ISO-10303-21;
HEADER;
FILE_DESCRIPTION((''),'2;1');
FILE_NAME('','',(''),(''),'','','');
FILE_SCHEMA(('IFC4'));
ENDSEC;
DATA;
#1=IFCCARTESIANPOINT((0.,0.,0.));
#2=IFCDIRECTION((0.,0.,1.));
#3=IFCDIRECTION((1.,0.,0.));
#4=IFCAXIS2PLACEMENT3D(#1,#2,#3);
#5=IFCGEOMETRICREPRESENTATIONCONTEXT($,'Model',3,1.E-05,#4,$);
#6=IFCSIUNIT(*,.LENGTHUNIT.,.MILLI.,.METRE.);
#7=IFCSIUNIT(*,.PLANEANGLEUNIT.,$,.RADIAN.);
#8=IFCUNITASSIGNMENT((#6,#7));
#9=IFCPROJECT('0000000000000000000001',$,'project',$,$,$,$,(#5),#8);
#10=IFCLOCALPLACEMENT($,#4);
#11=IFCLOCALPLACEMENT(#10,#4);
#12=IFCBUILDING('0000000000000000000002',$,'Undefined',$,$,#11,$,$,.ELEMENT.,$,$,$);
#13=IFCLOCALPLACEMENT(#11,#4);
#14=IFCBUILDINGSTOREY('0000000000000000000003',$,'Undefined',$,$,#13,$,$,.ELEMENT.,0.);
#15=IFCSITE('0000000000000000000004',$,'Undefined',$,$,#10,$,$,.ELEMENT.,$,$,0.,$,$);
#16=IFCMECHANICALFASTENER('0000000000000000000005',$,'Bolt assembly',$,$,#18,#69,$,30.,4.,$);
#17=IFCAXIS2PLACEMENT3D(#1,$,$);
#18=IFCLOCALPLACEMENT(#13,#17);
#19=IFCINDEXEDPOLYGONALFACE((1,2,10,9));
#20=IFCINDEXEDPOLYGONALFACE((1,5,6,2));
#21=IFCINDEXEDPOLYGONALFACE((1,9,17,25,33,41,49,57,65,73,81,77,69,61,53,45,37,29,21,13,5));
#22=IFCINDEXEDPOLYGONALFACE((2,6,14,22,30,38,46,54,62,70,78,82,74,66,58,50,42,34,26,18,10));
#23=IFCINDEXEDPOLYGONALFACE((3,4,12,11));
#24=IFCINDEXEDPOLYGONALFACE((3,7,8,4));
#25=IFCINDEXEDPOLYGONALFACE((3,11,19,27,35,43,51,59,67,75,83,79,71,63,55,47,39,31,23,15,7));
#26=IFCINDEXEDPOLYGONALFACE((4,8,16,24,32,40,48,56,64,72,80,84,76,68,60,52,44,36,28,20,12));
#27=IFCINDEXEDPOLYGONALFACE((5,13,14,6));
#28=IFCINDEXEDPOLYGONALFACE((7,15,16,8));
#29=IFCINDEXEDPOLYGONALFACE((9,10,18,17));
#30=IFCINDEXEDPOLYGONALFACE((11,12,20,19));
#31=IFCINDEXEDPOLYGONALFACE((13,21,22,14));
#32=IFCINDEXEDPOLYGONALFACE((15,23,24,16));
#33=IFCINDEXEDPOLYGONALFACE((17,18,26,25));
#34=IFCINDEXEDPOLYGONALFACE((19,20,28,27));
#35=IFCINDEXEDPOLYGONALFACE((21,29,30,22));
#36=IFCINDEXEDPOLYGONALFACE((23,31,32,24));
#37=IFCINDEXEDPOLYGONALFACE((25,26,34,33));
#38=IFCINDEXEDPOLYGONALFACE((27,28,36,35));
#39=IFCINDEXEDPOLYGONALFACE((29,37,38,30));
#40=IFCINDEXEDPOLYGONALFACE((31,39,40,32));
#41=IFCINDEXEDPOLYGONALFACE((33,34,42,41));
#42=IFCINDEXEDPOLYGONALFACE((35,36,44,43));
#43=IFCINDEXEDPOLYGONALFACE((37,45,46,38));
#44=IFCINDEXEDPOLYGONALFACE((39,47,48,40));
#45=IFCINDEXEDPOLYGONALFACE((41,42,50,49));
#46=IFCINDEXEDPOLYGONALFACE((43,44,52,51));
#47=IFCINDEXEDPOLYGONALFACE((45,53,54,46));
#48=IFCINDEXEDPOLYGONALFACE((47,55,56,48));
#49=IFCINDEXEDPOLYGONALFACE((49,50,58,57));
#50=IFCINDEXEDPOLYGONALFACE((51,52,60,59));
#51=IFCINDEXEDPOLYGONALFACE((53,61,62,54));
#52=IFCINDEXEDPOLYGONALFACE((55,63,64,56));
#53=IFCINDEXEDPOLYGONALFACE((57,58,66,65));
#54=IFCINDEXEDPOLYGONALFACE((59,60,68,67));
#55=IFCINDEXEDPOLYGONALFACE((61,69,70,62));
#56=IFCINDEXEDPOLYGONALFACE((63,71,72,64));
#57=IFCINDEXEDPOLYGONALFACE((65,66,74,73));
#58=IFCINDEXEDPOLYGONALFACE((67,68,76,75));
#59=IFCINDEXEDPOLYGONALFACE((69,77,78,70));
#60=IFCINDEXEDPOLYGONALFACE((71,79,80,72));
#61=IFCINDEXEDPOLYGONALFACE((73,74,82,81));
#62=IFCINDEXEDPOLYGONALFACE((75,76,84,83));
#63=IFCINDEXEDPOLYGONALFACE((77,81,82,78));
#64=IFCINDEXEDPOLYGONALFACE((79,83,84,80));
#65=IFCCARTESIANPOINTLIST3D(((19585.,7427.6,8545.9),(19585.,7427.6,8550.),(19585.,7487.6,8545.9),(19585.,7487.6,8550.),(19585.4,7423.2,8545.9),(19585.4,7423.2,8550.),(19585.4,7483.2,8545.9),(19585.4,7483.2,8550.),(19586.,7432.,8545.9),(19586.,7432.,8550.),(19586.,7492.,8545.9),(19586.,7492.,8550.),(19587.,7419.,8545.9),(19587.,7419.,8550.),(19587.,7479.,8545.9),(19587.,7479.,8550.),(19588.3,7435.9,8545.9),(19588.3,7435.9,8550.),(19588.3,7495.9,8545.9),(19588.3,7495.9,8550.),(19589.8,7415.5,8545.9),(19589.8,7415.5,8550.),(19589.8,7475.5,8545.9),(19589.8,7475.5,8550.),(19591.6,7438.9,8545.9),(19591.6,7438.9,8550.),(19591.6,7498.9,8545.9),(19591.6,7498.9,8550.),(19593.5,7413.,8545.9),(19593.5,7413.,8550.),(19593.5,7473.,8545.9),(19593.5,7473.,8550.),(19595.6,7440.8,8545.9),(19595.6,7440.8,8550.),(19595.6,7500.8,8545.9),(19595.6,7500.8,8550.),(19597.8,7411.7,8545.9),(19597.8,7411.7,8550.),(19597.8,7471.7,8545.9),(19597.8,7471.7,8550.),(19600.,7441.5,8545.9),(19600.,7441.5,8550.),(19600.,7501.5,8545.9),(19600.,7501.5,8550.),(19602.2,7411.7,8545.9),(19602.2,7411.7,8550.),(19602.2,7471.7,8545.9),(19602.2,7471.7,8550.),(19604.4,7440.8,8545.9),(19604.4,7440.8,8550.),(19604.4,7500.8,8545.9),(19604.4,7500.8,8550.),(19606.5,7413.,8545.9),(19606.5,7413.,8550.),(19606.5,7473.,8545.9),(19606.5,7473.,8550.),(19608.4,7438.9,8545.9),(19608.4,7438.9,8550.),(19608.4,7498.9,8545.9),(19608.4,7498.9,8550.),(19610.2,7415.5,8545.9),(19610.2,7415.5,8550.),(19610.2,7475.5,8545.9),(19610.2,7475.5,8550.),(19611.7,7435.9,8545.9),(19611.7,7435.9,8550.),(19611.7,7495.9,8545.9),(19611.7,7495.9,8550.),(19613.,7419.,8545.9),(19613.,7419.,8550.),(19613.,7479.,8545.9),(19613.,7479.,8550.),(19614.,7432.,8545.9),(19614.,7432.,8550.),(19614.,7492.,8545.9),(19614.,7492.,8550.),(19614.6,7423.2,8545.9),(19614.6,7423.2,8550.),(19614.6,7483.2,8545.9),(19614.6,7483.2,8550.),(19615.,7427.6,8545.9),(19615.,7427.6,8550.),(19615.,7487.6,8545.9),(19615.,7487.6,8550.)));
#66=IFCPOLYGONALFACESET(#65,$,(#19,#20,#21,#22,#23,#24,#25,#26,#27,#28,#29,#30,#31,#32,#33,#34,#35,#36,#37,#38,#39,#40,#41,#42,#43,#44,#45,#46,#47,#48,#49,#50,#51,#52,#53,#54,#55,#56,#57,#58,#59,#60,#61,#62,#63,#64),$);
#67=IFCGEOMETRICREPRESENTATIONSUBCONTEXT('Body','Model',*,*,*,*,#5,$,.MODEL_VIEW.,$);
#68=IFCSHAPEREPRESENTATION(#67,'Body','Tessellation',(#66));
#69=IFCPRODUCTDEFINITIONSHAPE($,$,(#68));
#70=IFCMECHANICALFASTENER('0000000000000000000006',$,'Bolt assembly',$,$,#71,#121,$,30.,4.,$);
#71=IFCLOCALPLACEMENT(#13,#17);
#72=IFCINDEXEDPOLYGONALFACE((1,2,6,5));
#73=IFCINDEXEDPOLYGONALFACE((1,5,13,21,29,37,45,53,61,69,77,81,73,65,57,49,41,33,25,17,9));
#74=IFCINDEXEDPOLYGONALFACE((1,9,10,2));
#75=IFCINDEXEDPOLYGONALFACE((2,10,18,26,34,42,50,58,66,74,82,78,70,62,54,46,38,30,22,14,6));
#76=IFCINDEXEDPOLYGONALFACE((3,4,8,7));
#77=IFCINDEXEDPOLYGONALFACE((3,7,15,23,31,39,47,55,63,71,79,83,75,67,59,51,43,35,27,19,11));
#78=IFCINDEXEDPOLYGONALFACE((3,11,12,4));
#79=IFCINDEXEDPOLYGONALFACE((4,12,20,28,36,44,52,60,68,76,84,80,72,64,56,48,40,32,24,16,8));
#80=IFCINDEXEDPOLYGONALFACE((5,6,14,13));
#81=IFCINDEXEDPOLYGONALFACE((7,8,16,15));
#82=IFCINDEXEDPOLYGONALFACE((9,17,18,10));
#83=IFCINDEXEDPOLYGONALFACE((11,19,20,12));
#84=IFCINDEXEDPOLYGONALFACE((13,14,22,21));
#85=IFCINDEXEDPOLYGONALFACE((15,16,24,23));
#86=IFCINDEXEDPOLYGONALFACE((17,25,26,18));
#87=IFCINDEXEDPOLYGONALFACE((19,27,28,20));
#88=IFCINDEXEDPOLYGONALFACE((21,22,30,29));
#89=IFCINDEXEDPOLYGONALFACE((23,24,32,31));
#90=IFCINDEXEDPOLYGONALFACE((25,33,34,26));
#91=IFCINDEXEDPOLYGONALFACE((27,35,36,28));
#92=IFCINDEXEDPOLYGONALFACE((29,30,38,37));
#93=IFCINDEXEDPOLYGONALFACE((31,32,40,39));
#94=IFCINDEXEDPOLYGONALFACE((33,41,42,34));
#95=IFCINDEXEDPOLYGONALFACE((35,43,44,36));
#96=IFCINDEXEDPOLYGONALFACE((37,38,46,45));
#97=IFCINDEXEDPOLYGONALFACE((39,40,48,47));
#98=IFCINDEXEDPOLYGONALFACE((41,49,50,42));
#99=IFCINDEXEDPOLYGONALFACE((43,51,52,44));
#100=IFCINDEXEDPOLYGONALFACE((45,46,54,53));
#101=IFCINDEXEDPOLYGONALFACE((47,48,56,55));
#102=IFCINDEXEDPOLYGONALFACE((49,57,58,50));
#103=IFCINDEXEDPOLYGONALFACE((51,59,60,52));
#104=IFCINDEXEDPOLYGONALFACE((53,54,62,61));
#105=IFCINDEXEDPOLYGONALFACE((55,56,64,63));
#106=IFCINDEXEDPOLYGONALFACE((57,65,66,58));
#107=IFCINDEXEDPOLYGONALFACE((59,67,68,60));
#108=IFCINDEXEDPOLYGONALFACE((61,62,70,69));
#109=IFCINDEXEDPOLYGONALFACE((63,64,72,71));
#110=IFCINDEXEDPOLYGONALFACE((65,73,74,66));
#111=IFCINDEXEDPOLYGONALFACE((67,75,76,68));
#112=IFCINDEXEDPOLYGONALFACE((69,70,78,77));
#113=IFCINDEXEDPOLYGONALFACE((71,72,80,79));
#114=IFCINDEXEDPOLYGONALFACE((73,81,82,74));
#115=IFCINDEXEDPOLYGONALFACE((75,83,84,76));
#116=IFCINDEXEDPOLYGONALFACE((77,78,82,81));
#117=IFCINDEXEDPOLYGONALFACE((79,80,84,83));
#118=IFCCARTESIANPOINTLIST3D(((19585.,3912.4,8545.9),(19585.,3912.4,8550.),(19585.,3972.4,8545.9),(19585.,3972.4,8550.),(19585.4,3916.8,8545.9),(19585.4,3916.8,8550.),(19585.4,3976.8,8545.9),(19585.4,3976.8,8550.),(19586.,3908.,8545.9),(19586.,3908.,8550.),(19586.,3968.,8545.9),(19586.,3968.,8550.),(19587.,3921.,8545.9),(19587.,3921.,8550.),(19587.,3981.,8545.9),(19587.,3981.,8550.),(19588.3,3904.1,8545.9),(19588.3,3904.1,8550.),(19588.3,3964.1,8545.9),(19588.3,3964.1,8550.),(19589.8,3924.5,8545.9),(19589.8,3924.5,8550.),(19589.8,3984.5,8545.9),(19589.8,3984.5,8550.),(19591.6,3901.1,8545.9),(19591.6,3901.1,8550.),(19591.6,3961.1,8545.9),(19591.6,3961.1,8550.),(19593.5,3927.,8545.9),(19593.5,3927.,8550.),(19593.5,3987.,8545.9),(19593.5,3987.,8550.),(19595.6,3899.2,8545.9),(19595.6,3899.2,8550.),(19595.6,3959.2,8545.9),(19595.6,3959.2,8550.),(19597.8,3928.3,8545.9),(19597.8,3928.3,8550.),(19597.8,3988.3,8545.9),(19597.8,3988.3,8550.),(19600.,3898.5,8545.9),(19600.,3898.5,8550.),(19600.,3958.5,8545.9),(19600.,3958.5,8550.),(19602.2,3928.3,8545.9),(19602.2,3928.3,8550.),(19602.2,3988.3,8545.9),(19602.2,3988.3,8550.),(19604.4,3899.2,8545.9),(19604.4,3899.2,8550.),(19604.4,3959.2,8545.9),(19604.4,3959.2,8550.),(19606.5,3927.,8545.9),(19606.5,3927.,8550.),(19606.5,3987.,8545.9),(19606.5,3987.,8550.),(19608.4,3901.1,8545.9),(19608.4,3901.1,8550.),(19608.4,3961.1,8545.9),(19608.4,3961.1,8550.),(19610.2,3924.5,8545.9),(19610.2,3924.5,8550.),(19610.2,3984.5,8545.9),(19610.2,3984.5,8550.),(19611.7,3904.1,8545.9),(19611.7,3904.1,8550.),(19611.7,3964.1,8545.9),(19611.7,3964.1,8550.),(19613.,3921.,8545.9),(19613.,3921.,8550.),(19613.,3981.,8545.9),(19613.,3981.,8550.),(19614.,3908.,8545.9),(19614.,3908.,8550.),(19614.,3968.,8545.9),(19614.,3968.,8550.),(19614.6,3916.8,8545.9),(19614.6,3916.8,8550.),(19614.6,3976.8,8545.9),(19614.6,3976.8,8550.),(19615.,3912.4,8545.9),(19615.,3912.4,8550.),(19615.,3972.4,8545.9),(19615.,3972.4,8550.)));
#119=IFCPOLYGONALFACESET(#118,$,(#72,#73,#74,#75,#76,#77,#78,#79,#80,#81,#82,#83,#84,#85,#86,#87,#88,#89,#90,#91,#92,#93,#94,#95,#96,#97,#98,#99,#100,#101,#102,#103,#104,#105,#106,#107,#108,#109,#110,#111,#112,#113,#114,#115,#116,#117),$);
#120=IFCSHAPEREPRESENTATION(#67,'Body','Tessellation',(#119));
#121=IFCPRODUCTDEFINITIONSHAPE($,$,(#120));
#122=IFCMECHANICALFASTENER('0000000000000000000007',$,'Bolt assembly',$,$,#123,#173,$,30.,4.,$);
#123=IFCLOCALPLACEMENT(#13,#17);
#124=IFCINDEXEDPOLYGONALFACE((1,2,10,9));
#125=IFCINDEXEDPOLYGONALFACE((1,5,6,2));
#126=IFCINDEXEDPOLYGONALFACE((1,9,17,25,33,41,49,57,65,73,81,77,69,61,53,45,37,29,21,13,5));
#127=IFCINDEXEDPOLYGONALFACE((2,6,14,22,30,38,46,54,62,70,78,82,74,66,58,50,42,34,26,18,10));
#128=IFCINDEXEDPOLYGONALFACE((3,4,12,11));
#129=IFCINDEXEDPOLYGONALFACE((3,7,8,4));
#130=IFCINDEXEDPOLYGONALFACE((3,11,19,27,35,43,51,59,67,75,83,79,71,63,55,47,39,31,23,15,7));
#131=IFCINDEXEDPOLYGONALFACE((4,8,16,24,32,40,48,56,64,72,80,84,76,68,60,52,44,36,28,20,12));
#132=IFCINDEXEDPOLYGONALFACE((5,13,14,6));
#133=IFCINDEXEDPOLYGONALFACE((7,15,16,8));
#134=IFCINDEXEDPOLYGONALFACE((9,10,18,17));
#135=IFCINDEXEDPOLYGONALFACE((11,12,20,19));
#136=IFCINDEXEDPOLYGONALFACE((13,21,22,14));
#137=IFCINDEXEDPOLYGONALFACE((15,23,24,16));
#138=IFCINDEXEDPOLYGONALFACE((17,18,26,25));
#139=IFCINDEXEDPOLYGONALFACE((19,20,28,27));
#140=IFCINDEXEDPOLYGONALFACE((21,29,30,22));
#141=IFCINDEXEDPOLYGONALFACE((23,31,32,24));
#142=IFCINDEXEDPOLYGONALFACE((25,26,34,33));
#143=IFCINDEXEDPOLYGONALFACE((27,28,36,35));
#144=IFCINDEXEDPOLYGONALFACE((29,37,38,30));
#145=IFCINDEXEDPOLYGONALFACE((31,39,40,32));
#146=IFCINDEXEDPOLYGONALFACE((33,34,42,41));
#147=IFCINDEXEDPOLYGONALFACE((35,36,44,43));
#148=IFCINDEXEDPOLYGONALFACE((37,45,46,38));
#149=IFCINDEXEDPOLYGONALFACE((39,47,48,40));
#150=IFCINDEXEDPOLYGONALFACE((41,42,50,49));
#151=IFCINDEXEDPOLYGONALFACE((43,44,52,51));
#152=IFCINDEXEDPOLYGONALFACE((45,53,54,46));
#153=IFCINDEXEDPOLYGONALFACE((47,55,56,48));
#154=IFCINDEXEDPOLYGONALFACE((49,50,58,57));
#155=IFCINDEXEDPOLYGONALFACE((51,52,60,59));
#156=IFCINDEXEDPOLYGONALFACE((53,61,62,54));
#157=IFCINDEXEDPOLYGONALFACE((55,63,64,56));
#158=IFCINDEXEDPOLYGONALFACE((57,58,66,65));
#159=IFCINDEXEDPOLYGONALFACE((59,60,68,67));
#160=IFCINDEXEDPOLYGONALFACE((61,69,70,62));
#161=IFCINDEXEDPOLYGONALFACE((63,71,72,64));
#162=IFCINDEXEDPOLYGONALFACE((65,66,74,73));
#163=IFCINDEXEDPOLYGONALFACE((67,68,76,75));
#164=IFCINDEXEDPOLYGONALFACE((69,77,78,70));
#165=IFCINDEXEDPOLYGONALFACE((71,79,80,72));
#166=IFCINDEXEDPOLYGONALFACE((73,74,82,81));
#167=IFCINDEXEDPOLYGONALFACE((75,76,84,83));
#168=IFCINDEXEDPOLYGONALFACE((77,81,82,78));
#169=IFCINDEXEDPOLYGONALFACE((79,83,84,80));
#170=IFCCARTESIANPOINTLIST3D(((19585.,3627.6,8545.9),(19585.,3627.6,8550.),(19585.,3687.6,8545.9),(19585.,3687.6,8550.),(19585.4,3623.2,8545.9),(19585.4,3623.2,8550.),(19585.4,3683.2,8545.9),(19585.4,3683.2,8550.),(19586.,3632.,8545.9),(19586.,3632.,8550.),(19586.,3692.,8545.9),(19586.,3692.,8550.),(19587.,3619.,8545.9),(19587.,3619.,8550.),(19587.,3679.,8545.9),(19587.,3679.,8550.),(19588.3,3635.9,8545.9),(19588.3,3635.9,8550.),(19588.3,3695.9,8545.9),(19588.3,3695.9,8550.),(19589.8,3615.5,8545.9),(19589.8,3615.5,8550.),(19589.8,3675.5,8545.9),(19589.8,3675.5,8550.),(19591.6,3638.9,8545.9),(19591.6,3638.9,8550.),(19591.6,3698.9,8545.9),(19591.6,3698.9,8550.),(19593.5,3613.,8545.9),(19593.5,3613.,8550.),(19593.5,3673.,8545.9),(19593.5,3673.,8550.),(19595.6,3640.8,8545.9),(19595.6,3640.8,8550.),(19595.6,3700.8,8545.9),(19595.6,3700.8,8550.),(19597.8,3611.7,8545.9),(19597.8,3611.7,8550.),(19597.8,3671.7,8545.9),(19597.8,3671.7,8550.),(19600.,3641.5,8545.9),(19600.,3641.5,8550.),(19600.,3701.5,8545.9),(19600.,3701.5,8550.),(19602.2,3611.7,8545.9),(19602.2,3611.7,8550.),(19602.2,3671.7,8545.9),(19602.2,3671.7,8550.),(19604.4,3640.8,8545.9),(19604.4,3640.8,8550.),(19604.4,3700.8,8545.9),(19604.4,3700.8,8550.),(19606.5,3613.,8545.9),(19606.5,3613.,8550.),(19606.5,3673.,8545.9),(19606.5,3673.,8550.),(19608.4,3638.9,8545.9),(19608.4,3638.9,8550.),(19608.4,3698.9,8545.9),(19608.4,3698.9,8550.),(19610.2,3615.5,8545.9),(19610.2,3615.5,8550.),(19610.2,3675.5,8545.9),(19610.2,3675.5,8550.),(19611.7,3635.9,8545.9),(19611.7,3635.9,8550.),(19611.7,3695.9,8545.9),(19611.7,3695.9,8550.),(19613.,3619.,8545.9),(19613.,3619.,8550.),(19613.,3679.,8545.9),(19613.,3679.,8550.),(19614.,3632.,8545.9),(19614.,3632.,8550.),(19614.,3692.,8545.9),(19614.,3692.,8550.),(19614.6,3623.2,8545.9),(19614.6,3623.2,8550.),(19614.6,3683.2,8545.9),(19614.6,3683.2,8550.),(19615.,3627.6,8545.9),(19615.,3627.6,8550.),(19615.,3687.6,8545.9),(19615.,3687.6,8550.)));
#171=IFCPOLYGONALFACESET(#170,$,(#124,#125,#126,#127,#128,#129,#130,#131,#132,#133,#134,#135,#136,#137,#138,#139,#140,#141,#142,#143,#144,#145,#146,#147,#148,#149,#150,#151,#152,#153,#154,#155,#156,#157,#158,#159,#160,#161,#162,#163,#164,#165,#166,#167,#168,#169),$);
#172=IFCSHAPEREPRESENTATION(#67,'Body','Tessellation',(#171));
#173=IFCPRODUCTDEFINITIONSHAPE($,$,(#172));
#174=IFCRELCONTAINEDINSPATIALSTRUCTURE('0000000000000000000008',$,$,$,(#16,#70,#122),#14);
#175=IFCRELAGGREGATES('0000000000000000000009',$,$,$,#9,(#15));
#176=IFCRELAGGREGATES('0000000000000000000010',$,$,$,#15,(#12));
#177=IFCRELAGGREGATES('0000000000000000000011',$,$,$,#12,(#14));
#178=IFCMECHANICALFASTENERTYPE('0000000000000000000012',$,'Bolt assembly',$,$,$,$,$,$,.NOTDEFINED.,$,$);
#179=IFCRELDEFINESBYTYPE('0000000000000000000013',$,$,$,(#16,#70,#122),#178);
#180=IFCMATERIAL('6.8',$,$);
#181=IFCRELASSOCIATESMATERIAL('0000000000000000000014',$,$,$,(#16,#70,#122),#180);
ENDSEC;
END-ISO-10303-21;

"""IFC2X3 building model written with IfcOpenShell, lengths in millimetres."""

from ifc_helpers import new_model, si_unit, frame, origin_with_axes, origin_2d_with_axis, place, context, subcontext, project, spatial, circle, extrude, source, transform, mapped, material, type_object, element, save


model = new_model("IFC2X3")

# Units and contexts
model_context = context("Model", 3, precision=1e-05, world=origin_with_axes())
body_context = subcontext(model_context, "Body", "Model", "MODEL_VIEW")
ifc_project = project(units=[si_unit("LENGTHUNIT", "METRE", prefix="MILLI"), si_unit("PLANEANGLEUNIT", "RADIAN")], contexts=[model_context])

# Site, building, storey
site_placement = place(None, origin_with_axes())
site = spatial("IfcSite", under=ifc_project, at=site_placement, Name="Undefined", CompositionType="ELEMENT", RefElevation=0.0)
building_placement = place(site_placement, origin_with_axes())
building = spatial("IfcBuilding", under=site, at=building_placement, Name="Undefined", CompositionType="ELEMENT")
storey_placement = place(building_placement, origin_with_axes())
storey = spatial("IfcBuildingStorey", under=building, at=storey_placement, Name="Undefined", CompositionType="ELEMENT", Elevation=0.0)

# Mechanical fasteners
ifc_material_1 = material(Name="6.8")
mechanical_fastener_type = type_object("IfcMechanicalFastenerType", Name="Bolt assembly")
shared_shape_1 = source(origin_with_axes(), body_context, "Body", "SweptSolid", [
    extrude(circle(Radius=15.0, at=origin_2d_with_axis()), frame((0.0, 0.0, 0.0), z_axis=(0.0, 1.0, 0.0), x_axis=(1.0, 0.0, 0.0)), (0.0, 0.0, 1.0), 4.1),
])
for number, where, z_axis, x_axis, name in (
    (1, (19600.0, 7426.5, 8550.0), (-1.0, 0.0, 0.0), (0.0, 1.0, 0.0), "Bolt assembly"),
    (2, (19600.0, 3973.5, 8550.0), (1.0, 0.0, 0.0), (0.0, -1.0, 0.0), "Bolt assembly"),
    (3, (19600.0, 3626.5, 8550.0), (-1.0, 0.0, 0.0), (0.0, 1.0, 0.0), "Bolt assembly"),
):
    element("IfcMechanicalFastener", number, at=place(storey_placement, frame(where, z_axis=z_axis, x_axis=x_axis)), inside=storey, type_object=mechanical_fastener_type, material=ifc_material_1, Name=name, NominalDiameter=30.0, NominalLength=4.0, context=body_context, shape_type="MappedRepresentation", body=[
        mapped(shared_shape_1, transform((0.0, 0.0, 0.0))),
        mapped(shared_shape_1, transform((60.0, 0.0, 0.0))),
    ])

save(model, "model.ifc")
